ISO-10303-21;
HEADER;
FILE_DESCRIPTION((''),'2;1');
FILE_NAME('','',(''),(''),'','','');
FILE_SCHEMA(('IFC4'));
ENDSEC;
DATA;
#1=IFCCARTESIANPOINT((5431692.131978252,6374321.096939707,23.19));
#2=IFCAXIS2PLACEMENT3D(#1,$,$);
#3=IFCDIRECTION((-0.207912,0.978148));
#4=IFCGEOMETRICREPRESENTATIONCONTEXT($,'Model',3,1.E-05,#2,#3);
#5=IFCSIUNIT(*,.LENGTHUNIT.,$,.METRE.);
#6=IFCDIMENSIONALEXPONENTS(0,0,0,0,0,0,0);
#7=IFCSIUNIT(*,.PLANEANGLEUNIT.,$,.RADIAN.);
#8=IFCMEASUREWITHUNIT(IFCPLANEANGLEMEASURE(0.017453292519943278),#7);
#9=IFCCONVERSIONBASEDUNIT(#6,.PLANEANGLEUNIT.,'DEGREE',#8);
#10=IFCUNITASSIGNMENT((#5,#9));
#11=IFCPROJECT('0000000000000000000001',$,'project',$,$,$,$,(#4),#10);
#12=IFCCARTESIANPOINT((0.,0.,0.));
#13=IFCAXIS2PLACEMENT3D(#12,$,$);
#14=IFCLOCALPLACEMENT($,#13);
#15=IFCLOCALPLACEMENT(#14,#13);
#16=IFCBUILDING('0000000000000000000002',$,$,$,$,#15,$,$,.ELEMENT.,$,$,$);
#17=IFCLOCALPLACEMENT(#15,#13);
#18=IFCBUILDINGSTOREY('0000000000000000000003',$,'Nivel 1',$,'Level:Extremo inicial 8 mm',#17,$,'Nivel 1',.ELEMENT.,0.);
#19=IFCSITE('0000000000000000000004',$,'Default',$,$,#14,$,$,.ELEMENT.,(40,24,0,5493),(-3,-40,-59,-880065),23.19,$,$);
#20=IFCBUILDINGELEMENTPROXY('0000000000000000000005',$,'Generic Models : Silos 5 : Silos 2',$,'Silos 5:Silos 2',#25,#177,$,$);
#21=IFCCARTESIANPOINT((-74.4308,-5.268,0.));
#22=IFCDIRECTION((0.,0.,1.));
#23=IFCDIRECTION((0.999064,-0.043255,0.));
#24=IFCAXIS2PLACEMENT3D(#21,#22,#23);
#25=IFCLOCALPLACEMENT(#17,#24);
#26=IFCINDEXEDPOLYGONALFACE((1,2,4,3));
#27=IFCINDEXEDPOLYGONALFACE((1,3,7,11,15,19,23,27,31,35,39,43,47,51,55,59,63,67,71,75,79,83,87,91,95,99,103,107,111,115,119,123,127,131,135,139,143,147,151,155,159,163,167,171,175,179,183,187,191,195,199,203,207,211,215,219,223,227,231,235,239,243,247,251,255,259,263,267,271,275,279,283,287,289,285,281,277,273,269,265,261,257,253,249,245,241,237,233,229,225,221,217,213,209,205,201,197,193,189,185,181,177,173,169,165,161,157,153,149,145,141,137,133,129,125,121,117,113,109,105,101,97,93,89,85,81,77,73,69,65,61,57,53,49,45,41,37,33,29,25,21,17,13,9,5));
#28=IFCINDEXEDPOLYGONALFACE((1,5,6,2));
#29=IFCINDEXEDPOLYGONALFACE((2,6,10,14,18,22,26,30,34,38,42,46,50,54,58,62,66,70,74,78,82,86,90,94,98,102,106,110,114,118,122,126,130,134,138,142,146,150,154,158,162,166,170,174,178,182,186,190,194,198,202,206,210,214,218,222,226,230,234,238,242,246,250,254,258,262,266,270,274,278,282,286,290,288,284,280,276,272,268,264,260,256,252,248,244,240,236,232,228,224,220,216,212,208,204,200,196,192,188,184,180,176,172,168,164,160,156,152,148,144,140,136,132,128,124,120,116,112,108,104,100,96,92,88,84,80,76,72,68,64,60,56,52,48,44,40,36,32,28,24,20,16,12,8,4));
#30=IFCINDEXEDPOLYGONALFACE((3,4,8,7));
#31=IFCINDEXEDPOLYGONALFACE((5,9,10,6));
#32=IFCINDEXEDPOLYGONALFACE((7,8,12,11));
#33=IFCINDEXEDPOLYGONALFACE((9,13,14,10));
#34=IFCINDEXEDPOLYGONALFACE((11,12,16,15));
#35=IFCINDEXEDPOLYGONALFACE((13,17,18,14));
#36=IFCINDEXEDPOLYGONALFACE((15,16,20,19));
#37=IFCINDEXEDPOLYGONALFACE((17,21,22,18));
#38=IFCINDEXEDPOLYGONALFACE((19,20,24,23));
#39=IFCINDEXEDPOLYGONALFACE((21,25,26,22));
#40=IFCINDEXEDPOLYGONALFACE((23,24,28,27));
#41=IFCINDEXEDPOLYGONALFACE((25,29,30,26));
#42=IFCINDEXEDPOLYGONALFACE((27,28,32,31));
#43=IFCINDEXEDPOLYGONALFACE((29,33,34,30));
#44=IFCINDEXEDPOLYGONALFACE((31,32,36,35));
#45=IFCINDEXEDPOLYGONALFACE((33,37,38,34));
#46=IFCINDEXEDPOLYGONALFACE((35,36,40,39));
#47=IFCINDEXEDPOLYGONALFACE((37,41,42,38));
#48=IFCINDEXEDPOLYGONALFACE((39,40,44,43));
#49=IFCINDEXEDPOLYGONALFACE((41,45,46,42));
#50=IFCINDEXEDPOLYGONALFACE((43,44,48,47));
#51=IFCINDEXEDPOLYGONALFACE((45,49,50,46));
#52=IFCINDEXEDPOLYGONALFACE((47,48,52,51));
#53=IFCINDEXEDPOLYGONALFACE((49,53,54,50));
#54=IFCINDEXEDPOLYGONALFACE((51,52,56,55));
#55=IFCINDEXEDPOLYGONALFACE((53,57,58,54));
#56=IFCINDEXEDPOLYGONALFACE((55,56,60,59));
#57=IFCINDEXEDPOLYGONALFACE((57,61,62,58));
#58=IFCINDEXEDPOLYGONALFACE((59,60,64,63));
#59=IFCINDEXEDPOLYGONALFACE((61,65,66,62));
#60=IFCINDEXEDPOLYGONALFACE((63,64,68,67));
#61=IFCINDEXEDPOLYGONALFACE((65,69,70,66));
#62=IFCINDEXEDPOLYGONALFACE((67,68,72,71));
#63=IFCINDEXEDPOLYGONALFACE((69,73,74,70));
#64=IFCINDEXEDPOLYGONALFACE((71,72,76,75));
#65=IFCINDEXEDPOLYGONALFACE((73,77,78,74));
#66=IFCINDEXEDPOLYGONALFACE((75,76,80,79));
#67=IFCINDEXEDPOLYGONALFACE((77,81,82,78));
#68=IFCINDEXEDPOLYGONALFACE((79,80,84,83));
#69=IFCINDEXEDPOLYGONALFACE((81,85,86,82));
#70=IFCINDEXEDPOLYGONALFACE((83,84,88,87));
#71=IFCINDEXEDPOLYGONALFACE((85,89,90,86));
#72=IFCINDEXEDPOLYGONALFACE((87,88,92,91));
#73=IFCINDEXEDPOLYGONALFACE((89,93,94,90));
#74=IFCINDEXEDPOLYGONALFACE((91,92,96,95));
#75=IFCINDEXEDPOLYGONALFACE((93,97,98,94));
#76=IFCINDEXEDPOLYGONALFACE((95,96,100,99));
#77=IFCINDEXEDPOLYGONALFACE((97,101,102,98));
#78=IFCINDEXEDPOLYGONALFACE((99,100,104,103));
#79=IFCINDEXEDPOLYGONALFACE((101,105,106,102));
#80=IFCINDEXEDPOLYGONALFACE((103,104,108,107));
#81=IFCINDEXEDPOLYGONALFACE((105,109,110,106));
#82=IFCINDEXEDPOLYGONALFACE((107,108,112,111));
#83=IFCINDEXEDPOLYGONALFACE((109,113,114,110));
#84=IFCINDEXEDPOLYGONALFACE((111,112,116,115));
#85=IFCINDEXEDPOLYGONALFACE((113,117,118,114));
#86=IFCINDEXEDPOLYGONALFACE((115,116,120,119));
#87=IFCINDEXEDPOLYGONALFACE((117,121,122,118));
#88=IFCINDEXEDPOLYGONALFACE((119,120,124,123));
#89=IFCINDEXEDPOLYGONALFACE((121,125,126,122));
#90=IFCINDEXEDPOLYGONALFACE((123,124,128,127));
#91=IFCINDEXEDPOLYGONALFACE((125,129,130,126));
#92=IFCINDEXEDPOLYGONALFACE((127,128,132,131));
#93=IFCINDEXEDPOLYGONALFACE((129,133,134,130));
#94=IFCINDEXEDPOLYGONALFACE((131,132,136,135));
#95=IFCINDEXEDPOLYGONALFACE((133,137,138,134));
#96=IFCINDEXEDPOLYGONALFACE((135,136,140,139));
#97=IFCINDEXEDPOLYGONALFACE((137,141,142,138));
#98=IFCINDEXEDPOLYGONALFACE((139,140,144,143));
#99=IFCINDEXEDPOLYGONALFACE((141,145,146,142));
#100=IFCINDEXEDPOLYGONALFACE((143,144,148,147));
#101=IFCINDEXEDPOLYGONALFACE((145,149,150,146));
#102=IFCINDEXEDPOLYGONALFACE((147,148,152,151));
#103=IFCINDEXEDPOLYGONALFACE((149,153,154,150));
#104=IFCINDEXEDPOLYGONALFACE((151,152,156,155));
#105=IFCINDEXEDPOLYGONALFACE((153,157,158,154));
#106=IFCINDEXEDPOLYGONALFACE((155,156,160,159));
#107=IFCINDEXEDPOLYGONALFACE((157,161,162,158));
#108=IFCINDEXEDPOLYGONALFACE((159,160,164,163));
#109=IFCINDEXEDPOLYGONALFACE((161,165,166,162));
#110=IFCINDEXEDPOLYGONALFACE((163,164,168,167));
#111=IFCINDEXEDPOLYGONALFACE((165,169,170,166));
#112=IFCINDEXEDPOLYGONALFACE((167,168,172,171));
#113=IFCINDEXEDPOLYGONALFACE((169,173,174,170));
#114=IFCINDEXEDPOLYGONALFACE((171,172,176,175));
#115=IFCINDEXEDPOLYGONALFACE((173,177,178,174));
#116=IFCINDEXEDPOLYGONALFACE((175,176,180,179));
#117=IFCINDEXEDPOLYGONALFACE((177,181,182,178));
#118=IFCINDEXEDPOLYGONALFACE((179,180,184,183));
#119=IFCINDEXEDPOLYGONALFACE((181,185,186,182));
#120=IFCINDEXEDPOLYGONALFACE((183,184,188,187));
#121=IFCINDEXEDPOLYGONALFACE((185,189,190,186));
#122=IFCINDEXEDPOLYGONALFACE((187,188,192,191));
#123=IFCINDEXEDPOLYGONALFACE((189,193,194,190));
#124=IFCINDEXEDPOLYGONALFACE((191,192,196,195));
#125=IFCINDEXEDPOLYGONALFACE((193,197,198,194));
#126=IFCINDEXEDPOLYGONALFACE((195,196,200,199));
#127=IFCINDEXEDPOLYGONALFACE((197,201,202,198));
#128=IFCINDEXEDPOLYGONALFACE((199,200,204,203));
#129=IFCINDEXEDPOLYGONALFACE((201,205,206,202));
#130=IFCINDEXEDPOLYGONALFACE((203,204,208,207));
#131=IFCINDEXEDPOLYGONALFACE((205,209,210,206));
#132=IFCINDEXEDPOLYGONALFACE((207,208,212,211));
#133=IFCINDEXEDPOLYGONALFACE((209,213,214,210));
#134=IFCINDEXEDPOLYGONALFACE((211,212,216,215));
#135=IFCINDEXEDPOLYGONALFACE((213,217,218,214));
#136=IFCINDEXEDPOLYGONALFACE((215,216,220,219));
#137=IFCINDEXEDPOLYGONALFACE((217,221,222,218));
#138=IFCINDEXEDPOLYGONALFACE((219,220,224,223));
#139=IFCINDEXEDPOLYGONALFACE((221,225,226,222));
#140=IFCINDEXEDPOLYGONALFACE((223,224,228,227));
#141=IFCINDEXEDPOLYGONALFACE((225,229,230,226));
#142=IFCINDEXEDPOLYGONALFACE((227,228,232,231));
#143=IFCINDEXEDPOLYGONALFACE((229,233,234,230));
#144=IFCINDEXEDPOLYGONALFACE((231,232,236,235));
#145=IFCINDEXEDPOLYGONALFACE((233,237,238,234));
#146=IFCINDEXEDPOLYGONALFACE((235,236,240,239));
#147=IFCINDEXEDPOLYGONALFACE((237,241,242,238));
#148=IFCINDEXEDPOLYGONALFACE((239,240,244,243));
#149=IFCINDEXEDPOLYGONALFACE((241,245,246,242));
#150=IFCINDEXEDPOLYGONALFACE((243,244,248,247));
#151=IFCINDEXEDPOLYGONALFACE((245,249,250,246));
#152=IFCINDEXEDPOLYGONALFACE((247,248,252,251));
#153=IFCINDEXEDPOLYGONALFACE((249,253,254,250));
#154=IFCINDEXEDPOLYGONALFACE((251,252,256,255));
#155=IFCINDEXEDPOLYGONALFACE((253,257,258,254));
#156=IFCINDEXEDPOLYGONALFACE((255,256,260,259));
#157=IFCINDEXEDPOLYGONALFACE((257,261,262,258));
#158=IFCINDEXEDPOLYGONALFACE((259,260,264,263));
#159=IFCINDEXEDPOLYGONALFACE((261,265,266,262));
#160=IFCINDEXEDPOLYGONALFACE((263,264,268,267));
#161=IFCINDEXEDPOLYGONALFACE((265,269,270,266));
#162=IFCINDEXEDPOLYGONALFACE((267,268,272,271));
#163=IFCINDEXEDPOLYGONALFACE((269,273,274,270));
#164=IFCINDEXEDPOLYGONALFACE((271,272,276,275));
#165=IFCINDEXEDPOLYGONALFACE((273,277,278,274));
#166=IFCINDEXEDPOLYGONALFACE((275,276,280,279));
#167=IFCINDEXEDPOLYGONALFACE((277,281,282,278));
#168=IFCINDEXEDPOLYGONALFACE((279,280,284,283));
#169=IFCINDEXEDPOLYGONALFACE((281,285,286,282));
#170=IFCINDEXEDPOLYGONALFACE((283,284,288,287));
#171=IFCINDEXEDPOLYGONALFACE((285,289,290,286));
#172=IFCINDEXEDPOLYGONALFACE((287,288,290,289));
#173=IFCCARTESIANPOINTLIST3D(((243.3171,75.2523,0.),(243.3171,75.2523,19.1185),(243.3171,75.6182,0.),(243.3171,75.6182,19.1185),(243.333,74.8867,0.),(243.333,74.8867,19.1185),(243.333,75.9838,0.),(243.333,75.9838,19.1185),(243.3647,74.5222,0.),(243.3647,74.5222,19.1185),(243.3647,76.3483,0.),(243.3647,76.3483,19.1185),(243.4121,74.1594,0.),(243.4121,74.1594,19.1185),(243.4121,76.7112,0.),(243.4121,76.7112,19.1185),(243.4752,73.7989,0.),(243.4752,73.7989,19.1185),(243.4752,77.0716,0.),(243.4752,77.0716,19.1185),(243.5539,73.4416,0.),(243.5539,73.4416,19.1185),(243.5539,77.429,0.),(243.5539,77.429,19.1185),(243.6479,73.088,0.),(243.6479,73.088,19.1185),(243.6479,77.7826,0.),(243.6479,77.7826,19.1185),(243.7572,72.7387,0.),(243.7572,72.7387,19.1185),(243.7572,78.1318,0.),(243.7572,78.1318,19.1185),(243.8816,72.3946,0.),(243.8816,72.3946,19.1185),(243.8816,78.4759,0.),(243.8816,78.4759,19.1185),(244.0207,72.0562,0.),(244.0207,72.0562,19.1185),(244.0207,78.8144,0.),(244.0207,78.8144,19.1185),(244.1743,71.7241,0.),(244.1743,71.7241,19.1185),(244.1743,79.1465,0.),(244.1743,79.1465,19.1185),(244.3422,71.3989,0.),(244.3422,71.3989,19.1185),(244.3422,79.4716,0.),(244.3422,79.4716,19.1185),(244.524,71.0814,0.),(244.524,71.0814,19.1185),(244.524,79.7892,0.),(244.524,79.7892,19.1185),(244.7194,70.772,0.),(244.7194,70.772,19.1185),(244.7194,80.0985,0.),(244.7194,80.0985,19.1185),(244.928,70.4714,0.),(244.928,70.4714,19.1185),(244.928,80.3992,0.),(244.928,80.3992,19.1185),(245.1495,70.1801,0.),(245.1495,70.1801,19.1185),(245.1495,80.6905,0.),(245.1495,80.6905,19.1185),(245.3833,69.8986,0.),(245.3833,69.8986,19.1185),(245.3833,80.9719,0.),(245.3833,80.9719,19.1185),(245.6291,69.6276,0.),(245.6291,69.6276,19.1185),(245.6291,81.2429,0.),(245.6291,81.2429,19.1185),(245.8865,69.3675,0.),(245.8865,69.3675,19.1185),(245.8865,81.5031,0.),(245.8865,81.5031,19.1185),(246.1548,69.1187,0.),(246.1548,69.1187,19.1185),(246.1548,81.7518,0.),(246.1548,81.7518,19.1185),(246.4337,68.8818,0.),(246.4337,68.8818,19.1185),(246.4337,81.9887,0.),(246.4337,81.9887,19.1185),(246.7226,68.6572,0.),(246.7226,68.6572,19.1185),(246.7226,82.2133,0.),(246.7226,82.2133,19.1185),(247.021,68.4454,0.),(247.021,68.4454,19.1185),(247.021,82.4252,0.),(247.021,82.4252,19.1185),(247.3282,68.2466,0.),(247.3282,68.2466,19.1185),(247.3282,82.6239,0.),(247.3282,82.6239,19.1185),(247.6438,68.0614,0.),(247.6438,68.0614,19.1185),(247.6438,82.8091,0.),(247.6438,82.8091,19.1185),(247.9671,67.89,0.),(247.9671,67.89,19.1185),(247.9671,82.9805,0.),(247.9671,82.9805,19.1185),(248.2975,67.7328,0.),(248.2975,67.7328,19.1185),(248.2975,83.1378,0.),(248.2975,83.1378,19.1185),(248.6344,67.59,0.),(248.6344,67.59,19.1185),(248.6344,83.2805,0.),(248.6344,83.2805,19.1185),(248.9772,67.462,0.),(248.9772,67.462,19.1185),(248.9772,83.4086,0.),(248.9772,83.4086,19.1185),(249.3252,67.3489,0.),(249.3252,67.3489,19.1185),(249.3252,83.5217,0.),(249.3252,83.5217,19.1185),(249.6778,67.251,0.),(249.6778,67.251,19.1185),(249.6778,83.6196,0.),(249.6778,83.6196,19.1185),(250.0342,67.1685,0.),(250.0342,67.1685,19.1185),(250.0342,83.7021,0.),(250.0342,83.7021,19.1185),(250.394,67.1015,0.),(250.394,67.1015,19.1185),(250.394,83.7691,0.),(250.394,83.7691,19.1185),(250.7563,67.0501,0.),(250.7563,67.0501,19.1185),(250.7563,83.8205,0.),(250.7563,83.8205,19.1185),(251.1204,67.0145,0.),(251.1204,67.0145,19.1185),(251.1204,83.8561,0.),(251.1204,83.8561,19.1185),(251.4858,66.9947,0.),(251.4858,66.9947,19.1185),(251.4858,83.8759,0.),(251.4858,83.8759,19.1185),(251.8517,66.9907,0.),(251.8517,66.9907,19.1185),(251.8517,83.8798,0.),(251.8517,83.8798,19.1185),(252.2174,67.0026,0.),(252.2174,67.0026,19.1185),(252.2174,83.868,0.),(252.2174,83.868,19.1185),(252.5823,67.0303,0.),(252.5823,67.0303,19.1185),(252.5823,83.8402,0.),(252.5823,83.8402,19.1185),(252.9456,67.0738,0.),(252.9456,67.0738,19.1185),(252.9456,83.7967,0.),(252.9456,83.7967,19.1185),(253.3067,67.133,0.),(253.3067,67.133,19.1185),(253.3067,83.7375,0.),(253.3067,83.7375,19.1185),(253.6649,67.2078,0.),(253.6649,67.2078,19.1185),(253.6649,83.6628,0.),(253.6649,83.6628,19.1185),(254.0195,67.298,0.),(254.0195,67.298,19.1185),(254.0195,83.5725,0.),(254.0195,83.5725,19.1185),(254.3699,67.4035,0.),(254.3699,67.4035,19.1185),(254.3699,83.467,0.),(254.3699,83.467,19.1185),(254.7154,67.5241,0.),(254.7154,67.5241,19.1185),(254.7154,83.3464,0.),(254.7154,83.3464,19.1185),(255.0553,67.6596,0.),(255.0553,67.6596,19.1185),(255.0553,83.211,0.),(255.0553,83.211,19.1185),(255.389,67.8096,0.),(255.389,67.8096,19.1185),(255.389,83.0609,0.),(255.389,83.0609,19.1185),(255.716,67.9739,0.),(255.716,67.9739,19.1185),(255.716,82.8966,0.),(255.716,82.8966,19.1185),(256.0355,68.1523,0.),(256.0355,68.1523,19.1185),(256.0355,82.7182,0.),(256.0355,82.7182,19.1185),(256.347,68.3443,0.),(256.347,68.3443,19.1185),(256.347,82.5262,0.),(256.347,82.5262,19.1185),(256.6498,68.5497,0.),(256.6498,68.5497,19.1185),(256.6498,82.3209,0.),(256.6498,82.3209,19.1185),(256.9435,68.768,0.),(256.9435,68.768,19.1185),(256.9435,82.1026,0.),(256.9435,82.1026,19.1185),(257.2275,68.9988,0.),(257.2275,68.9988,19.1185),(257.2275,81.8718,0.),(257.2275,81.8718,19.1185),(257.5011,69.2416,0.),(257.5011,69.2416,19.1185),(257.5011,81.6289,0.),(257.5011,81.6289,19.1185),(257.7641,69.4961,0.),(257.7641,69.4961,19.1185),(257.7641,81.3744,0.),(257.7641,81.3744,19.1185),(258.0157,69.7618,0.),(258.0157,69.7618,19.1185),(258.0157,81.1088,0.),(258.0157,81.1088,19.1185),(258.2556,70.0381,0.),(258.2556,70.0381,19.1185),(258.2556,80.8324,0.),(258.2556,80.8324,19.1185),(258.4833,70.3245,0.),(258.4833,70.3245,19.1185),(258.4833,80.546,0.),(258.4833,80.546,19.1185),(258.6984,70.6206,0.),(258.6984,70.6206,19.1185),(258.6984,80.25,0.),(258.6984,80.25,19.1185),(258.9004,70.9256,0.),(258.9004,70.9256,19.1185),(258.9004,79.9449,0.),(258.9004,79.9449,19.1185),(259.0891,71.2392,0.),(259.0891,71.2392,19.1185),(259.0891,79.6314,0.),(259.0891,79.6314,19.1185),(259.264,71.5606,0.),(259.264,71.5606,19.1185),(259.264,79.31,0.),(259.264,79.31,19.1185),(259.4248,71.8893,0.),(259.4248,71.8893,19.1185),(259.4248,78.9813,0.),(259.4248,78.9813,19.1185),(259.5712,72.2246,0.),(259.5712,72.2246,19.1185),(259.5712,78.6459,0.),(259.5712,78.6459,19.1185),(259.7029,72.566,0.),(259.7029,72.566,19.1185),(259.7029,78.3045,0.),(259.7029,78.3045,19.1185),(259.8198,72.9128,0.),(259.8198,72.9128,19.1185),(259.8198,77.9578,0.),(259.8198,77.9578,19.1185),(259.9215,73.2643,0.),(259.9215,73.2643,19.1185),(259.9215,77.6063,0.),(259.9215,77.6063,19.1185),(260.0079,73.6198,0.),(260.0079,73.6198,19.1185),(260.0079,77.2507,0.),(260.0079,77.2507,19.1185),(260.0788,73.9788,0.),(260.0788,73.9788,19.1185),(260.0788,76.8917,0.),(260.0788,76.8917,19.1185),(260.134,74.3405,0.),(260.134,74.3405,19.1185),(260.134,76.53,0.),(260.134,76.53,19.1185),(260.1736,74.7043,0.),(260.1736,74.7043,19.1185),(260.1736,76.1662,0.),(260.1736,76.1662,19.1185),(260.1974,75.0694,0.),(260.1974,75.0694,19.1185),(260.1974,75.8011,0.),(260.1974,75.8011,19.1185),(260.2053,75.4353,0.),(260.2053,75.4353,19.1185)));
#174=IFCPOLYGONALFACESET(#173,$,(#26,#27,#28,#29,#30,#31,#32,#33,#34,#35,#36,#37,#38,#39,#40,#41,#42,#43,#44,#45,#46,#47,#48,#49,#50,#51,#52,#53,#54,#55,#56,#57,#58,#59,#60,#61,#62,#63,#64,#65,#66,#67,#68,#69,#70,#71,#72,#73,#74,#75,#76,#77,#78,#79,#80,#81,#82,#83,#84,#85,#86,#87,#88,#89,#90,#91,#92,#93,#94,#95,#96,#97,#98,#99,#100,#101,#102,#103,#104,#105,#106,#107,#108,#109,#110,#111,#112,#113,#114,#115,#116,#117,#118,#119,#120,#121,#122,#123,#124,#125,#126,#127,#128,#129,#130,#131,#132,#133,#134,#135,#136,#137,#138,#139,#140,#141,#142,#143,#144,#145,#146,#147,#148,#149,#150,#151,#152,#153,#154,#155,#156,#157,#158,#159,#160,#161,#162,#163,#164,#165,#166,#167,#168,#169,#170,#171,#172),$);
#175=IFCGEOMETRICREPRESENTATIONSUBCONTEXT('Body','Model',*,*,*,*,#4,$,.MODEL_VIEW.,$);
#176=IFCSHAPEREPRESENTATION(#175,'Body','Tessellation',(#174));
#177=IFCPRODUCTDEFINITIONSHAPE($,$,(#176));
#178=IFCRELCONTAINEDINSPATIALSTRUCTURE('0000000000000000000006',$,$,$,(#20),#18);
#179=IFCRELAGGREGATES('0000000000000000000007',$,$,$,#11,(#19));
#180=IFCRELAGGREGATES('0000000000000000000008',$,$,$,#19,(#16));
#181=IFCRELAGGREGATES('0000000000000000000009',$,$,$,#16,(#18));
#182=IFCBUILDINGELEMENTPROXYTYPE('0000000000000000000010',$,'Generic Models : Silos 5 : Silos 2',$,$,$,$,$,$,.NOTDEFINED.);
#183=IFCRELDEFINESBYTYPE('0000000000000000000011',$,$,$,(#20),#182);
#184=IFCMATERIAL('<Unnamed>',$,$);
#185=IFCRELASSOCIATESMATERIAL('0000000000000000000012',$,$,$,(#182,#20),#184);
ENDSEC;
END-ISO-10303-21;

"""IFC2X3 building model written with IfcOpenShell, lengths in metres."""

from ifc_helpers import new_model, entity, si_unit, converted_unit, direction, frame, frame_2d, origin, place, context, subcontext, project, spatial, circle, extrude, source, transform, mapped, material, type_object, type_shapes, element, save


model = new_model("IFC2X3")

# Units and contexts
model_context = context("Model", 3, precision=1e-05, world=frame((5431692.131978252, 6374321.096939707, 23.19)), true_north=direction((-0.207912, 0.978148)))
body_context = subcontext(model_context, "Body", "Model", "MODEL_VIEW")
ifc_project = project(units=[si_unit("LENGTHUNIT", "METRE"), converted_unit("PLANEANGLEUNIT", "DEGREE", entity("IfcPlaneAngleMeasure", 0.017453292519943278), si_unit("PLANEANGLEUNIT", "RADIAN"), dimensions=[0, 0, 0, 0, 0, 0, 0])], contexts=[model_context])

# Site, building, storey
site_placement = place(None, origin())
site = spatial("IfcSite", under=ifc_project, at=site_placement, Name="Default", CompositionType="ELEMENT", RefLatitude=(40, 24, 0, 5493), RefLongitude=(-3, -40, -59, -880065), RefElevation=23.19)
building_placement = place(site_placement, origin())
building = spatial("IfcBuilding", under=site, at=building_placement, CompositionType="ELEMENT")
storey_placement = place(building_placement, origin())
storey = spatial("IfcBuildingStorey", under=building, at=storey_placement, Name="Nivel 1", ObjectType="Level:Extremo inicial 8 mm", LongName="Nivel 1", CompositionType="ELEMENT", Elevation=0.0)

# Building element proxy
ifc_material_1 = material(Name="<Unnamed>")
building_element_proxy_type_1 = type_object("IfcBuildingElementProxyType", Name="Generic Models : Silos 5 : Silos 2", PredefinedType="NOTDEFINED", material=ifc_material_1)
shared_shape_1 = source(origin(), body_context, "Body", "SweptSolid", [
    extrude(circle(Radius=8.4451, at=frame_2d((0.0, 0.0), x_axis=(1.0, 0.0))), frame((251.7602, 75.4353, 0.0)), (0.0, 0.0, 1.0), 19.1185),
])
type_shapes(building_element_proxy_type_1, [shared_shape_1])
proxy_1_placement = place(storey_placement, frame((-74.4308, -5.268, 0.0), z_axis=(0.0, 0.0, 1.0), x_axis=(0.999064, -0.043255, 0.0)))
element("IfcBuildingElementProxy", 1, at=proxy_1_placement, inside=storey, type_object=building_element_proxy_type_1, material=ifc_material_1, Name="Generic Models : Silos 5 : Silos 2", ObjectType="Silos 5:Silos 2", context=body_context, shape_type="MappedRepresentation", body=[
    mapped(shared_shape_1, transform((0.0, 0.0, 0.0), scale=1.0)),
])

save(model, "model.ifc")
